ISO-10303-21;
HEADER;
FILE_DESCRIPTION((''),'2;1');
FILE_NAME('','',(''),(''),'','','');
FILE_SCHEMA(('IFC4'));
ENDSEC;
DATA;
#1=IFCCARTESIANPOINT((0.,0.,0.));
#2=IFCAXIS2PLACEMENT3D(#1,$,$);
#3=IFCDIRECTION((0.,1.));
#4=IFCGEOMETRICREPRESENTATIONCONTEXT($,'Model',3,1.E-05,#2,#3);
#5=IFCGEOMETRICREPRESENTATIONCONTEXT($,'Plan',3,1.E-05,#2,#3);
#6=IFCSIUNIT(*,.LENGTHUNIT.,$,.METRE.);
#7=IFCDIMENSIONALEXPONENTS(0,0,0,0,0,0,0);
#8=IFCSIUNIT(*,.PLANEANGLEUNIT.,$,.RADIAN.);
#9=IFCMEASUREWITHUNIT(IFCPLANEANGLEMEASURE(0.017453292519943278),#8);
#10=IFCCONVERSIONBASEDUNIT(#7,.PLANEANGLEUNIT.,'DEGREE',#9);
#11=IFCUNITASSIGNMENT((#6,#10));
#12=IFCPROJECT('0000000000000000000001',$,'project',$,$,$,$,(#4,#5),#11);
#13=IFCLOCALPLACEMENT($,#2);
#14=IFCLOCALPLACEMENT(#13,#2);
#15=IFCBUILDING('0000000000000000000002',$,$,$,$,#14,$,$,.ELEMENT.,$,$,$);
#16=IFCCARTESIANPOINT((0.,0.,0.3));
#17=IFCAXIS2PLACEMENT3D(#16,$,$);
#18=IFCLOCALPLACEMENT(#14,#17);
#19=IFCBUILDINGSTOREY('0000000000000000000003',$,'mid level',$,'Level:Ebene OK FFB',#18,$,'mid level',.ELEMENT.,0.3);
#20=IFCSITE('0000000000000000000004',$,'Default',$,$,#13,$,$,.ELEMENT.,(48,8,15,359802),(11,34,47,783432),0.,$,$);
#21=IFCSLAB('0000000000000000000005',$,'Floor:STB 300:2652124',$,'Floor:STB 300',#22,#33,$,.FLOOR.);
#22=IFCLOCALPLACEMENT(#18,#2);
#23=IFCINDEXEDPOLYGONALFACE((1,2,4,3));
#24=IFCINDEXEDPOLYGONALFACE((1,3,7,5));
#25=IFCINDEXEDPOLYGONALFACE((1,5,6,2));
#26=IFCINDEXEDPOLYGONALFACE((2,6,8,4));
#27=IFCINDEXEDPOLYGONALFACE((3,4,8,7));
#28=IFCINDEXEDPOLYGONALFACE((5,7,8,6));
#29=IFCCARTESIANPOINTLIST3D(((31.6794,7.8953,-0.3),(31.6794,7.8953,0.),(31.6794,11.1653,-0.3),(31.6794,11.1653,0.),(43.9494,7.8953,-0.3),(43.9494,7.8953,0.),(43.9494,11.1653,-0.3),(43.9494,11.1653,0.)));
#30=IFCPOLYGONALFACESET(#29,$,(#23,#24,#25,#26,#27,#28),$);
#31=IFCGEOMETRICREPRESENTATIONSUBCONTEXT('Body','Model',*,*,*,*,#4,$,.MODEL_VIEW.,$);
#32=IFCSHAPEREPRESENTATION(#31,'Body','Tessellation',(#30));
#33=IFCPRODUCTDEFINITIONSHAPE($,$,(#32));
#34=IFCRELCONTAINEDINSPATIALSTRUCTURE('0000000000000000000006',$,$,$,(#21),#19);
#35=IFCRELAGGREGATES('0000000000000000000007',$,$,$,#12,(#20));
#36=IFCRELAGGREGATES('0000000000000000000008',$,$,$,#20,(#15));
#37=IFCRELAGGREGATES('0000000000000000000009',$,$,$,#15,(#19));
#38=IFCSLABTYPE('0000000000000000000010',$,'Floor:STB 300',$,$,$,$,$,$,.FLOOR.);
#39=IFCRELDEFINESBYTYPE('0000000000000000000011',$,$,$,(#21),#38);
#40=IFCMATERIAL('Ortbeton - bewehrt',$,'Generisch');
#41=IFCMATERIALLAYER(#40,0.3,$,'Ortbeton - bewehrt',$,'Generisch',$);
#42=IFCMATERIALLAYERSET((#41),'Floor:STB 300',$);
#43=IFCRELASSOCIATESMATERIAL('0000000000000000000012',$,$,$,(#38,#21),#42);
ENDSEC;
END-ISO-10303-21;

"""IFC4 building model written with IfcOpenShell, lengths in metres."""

from ifc_helpers import new_model, entity, si_unit, converted_unit, direction, frame, frame_2d, origin, place, context, subcontext, project, spatial, rectangle, extrude, material, layer, layer_set, layer_usage, type_object, element, save


model = new_model("IFC4")

# Units and contexts
model_context = context("Model", 3, precision=1e-05, world=origin(), true_north=direction((0.0, 1.0)))
plan_context = context("Plan", 3, precision=1e-05, world=origin(), true_north=direction((0.0, 1.0)))
body_context = subcontext(model_context, "Body", "Model", "MODEL_VIEW")
ifc_project = project(units=[si_unit("LENGTHUNIT", "METRE"), converted_unit("PLANEANGLEUNIT", "DEGREE", entity("IfcPlaneAngleMeasure", 0.017453292519943278), si_unit("PLANEANGLEUNIT", "RADIAN"), dimensions=[0, 0, 0, 0, 0, 0, 0])], contexts=[model_context, plan_context])

# Site, building, storey
site_placement = place(None, origin())
site = spatial("IfcSite", under=ifc_project, at=site_placement, Name="Default", CompositionType="ELEMENT", RefLatitude=(48, 8, 15, 359802), RefLongitude=(11, 34, 47, 783432), RefElevation=0.0)
building_placement = place(site_placement, origin())
building = spatial("IfcBuilding", under=site, at=building_placement, CompositionType="ELEMENT")
storey_placement = place(building_placement, frame((0.0, 0.0, 0.3)))
storey = spatial("IfcBuildingStorey", under=building, at=storey_placement, Name="mid level", ObjectType="Level:Ebene OK FFB", LongName="mid level", CompositionType="ELEMENT", Elevation=0.3)

# Slab
ifc_material = material(Name="Ortbeton - bewehrt", Category="Generisch")
ifc_layer = layer(ifc_material, 0.3, Name="Ortbeton - bewehrt", Category="Generisch")
ifc_layer_set = layer_set([ifc_layer], Name="Floor:STB 300")
ifc_layer_usage = layer_usage(ifc_layer_set, "AXIS3", "POSITIVE", 0.0)
slab_type = type_object("IfcSlabType", Name="Floor:STB 300", PredefinedType="FLOOR", material=ifc_layer_set)
slab_placement = place(storey_placement, origin())
element("IfcSlab", 1, at=slab_placement, inside=storey, type_object=slab_type, material=ifc_layer_usage, Name="Floor:STB 300:2652124", ObjectType="Floor:STB 300", PredefinedType="FLOOR", context=body_context, shape_type="SweptSolid", body=[
    extrude(rectangle(XDim=3.27, YDim=12.27, at=frame_2d((0.0, 0.0), x_axis=(1.0, 0.0))), frame((37.8144, 9.5303, 0.0), z_axis=(0.0, 0.0, -1.0), x_axis=(0.0, 1.0, 0.0)), (0.0, 0.0, 1.0), 0.3),
])

save(model, "model.ifc")
